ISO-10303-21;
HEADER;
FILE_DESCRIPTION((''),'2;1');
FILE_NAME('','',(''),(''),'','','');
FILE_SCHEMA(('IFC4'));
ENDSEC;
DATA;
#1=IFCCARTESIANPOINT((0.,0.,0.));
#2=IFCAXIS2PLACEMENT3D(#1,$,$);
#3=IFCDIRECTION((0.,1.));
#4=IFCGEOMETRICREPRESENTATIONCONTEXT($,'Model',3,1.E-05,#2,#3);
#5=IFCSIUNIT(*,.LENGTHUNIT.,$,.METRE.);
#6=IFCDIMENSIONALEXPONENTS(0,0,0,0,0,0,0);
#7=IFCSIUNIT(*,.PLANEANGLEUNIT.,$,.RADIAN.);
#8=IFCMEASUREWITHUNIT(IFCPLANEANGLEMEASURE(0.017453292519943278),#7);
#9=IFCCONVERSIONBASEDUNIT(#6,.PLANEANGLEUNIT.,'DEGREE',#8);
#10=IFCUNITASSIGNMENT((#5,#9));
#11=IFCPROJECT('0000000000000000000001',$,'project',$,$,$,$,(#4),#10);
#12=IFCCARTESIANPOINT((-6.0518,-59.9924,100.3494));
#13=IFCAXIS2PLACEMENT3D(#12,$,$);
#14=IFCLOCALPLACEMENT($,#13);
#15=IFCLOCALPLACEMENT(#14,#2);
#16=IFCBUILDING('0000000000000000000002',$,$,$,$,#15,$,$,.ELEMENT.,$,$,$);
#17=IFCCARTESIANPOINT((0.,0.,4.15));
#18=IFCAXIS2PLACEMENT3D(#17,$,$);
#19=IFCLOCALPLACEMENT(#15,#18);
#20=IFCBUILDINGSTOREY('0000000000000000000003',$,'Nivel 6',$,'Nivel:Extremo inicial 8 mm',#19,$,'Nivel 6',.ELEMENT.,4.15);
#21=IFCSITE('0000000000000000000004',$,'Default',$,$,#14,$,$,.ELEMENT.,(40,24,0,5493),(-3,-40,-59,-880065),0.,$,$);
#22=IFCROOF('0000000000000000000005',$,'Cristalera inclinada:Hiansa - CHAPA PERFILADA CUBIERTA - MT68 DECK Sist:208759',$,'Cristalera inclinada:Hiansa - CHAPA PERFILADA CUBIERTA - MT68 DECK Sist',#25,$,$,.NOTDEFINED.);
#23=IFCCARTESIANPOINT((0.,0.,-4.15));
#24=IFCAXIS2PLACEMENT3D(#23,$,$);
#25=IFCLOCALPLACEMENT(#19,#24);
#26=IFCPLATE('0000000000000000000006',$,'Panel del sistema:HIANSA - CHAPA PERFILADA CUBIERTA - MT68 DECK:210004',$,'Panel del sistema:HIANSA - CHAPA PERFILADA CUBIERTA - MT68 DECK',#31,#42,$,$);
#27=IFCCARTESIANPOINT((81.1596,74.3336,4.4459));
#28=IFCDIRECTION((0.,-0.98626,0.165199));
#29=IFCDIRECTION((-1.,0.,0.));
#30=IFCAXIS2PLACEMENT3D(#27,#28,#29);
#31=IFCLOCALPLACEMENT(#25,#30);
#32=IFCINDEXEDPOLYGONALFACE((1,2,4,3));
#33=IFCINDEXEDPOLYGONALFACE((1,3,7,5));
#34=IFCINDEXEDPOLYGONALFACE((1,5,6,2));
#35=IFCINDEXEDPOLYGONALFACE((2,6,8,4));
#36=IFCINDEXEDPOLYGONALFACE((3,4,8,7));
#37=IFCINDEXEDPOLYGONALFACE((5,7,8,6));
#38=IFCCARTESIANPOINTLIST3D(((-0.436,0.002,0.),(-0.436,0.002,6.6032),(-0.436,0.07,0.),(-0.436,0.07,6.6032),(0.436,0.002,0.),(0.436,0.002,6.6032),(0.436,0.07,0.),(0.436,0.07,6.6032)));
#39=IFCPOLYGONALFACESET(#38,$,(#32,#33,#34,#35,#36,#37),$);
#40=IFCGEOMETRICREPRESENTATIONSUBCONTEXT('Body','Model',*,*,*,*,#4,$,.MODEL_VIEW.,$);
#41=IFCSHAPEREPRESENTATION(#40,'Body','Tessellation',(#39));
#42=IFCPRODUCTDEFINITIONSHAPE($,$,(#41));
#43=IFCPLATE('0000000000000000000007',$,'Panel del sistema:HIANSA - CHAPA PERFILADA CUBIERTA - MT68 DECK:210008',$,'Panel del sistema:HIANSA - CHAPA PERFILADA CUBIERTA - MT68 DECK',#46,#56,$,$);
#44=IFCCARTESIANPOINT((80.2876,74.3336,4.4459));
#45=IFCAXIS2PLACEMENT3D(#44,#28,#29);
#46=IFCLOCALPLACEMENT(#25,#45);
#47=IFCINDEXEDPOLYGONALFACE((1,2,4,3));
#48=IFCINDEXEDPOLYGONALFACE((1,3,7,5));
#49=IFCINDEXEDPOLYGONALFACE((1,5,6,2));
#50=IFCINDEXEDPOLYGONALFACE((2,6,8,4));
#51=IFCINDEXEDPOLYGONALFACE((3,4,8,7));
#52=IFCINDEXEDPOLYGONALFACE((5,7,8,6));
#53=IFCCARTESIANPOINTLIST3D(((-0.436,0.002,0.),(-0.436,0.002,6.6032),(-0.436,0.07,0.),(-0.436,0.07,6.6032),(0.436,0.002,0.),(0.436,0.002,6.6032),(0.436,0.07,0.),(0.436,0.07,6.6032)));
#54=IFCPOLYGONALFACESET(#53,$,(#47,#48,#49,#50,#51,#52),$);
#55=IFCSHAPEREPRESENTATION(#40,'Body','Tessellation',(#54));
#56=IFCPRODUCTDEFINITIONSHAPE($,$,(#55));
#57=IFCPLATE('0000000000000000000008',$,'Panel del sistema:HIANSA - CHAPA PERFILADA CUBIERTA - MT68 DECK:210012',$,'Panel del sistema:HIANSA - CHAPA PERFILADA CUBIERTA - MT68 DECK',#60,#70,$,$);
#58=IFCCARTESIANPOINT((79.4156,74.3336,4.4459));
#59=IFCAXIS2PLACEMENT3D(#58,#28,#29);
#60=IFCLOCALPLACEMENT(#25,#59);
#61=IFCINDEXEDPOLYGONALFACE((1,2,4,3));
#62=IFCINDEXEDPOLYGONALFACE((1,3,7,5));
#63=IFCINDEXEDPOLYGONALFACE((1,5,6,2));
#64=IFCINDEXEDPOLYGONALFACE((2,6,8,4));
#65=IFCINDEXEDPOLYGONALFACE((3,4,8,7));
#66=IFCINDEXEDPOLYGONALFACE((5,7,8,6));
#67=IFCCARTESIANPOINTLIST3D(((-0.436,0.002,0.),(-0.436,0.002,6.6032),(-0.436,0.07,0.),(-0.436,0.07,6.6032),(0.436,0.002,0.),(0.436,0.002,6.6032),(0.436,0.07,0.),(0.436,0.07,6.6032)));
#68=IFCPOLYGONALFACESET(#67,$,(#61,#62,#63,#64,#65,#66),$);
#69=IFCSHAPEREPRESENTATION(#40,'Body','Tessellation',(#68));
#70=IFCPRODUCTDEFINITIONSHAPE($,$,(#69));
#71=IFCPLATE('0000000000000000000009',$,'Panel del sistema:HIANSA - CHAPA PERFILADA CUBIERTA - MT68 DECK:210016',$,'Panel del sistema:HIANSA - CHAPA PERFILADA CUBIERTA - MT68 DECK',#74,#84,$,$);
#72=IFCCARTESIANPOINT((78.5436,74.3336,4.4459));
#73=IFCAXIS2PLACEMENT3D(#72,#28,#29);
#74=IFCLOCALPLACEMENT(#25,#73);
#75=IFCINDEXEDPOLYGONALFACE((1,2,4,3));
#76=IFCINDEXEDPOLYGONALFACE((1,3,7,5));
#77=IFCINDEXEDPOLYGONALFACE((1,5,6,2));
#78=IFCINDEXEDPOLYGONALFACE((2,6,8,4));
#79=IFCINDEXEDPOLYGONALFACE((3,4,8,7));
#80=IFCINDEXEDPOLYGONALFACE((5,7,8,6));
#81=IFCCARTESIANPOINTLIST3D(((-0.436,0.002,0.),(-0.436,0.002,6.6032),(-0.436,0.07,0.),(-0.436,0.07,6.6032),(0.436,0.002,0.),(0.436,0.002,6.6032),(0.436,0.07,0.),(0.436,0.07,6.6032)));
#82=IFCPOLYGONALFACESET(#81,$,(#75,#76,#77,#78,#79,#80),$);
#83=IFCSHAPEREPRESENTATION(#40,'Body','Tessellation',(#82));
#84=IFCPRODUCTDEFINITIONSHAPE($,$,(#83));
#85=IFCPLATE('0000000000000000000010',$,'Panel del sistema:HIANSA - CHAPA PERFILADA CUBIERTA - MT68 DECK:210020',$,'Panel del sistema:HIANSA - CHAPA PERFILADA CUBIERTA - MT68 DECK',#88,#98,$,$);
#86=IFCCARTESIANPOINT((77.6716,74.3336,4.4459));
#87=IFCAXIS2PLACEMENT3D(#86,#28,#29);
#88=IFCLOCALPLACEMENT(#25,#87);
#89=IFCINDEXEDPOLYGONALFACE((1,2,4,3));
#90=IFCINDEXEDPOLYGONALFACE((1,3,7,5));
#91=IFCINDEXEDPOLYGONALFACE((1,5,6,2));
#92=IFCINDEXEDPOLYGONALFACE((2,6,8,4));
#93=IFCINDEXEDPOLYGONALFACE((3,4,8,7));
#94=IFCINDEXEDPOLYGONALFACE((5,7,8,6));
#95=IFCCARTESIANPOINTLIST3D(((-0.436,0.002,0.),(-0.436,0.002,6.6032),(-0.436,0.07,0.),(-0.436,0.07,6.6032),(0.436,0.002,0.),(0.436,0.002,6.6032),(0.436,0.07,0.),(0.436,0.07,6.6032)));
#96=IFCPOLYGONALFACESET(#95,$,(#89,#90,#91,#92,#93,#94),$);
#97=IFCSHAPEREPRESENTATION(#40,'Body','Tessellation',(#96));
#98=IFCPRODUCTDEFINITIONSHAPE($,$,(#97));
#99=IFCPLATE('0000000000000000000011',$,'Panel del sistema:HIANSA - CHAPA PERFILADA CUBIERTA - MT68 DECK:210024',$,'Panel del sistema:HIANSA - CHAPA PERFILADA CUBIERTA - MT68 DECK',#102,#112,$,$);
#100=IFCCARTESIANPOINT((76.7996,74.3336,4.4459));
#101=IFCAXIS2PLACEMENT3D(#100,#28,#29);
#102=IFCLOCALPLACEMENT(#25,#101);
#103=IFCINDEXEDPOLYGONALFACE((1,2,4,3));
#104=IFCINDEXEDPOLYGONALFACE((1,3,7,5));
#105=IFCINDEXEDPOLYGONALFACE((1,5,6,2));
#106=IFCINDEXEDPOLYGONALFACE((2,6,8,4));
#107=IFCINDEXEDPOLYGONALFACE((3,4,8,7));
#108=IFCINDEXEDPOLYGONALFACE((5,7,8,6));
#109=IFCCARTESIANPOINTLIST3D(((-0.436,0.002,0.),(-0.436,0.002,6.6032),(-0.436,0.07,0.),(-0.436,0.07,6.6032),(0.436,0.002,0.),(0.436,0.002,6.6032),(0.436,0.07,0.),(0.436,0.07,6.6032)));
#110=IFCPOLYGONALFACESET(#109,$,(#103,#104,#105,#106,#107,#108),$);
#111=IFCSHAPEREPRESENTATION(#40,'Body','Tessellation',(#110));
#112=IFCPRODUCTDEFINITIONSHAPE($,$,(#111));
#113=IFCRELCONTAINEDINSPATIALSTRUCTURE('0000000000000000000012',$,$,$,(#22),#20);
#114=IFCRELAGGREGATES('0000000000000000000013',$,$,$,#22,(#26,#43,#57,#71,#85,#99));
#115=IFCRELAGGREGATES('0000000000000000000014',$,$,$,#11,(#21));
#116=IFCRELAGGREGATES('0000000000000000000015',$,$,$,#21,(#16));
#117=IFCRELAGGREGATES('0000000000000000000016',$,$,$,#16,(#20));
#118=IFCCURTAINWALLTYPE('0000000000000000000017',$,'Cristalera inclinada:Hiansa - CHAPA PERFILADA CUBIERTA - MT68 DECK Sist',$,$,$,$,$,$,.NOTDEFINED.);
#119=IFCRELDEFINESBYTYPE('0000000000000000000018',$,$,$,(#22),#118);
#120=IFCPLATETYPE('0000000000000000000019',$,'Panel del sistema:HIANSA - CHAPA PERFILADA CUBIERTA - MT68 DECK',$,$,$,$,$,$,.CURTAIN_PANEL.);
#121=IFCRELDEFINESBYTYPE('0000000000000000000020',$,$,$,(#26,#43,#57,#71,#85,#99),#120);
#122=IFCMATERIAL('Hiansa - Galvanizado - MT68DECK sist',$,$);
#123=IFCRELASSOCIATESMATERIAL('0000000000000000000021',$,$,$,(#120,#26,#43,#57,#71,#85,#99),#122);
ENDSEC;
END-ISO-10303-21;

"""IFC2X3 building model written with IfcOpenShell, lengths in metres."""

from ifc_helpers import new_model, entity, si_unit, converted_unit, direction, frame, origin, origin_2d_with_axis, place, context, subcontext, project, spatial, rectangle, extrude, source, transform, mapped, material, type_object, type_shapes, element, aggregate, save


model = new_model("IFC2X3")

# Units and contexts
model_context = context("Model", 3, precision=1e-05, world=origin(), true_north=direction((0.0, 1.0)))
body_context = subcontext(model_context, "Body", "Model", "MODEL_VIEW")
ifc_project = project(units=[si_unit("LENGTHUNIT", "METRE"), converted_unit("PLANEANGLEUNIT", "DEGREE", entity("IfcPlaneAngleMeasure", 0.017453292519943278), si_unit("PLANEANGLEUNIT", "RADIAN"), dimensions=[0, 0, 0, 0, 0, 0, 0])], contexts=[model_context])

# Site, building, storey
site_placement = place(None, frame((-6.0518, -59.9924, 100.3494)))
site = spatial("IfcSite", under=ifc_project, at=site_placement, Name="Default", CompositionType="ELEMENT", RefLatitude=(40, 24, 0, 5493), RefLongitude=(-3, -40, -59, -880065), RefElevation=0.0)
building_placement = place(site_placement, origin())
building = spatial("IfcBuilding", under=site, at=building_placement, CompositionType="ELEMENT")
storey_placement = place(building_placement, frame((0.0, 0.0, 4.15)))
storey = spatial("IfcBuildingStorey", under=building, at=storey_placement, Name="Nivel 6", ObjectType="Nivel:Extremo inicial 8 mm", LongName="Nivel 6", CompositionType="ELEMENT", Elevation=4.15)

# Roof, plates
curtain_wall_type = type_object("IfcCurtainWallType", Name="Cristalera inclinada:Hiansa - CHAPA PERFILADA CUBIERTA - MT68 DECK Sist", PredefinedType="NOTDEFINED")
roof_placement = place(storey_placement, frame((0.0, 0.0, -4.15)))
roof = element("IfcRoof", 1, at=roof_placement, inside=storey, type_object=curtain_wall_type, Name="Cristalera inclinada:Hiansa - CHAPA PERFILADA CUBIERTA - MT68 DECK Sist:208759", ObjectType="Cristalera inclinada:Hiansa - CHAPA PERFILADA CUBIERTA - MT68 DECK Sist", ShapeType="NOTDEFINED")
ifc_material_1 = material(Name="Hiansa - Galvanizado - MT68DECK sist")
plate_type_1 = type_object("IfcPlateType", Name="Panel del sistema:HIANSA - CHAPA PERFILADA CUBIERTA - MT68 DECK", PredefinedType="CURTAIN_PANEL", material=ifc_material_1)
shared_shape_1 = source(origin(), body_context, "Body", "SweptSolid", [
    extrude(rectangle(XDim=0.068, YDim=0.872, at=origin_2d_with_axis()), frame((0.0, 0.036, 0.0), z_axis=(0.0, 0.0, 1.0), x_axis=(0.0, 1.0, 0.0)), (0.0, 0.0, 1.0), 6.6032),
])
type_shapes(plate_type_1, [shared_shape_1])
plate_1_placement = place(roof_placement, frame((81.1596, 74.3336, 4.4459), z_axis=(0.0, -0.98626, 0.165199), x_axis=(-1.0, 0.0, 0.0)))
plate_1 = element("IfcPlate", 2, at=plate_1_placement, type_object=plate_type_1, material=ifc_material_1, Name="Panel del sistema:HIANSA - CHAPA PERFILADA CUBIERTA - MT68 DECK:210004", ObjectType="Panel del sistema:HIANSA - CHAPA PERFILADA CUBIERTA - MT68 DECK", context=body_context, shape_type="MappedRepresentation", body=[
    mapped(shared_shape_1, transform((0.0, 0.0, 0.0), scale=1.0)),
])
plate_2_placement = place(roof_placement, frame((80.2876, 74.3336, 4.4459), z_axis=(0.0, -0.98626, 0.165199), x_axis=(-1.0, 0.0, 0.0)))
plate_2 = element("IfcPlate", 3, at=plate_2_placement, type_object=plate_type_1, material=ifc_material_1, Name="Panel del sistema:HIANSA - CHAPA PERFILADA CUBIERTA - MT68 DECK:210008", ObjectType="Panel del sistema:HIANSA - CHAPA PERFILADA CUBIERTA - MT68 DECK", context=body_context, shape_type="MappedRepresentation", body=[
    mapped(shared_shape_1, transform((0.0, 0.0, 0.0), scale=1.0)),
])
plate_3_placement = place(roof_placement, frame((79.4156, 74.3336, 4.4459), z_axis=(0.0, -0.98626, 0.165199), x_axis=(-1.0, 0.0, 0.0)))
plate_3 = element("IfcPlate", 4, at=plate_3_placement, type_object=plate_type_1, material=ifc_material_1, Name="Panel del sistema:HIANSA - CHAPA PERFILADA CUBIERTA - MT68 DECK:210012", ObjectType="Panel del sistema:HIANSA - CHAPA PERFILADA CUBIERTA - MT68 DECK", context=body_context, shape_type="MappedRepresentation", body=[
    mapped(shared_shape_1, transform((0.0, 0.0, 0.0), scale=1.0)),
])
plate_4_placement = place(roof_placement, frame((78.5436, 74.3336, 4.4459), z_axis=(0.0, -0.98626, 0.165199), x_axis=(-1.0, 0.0, 0.0)))
plate_4 = element("IfcPlate", 5, at=plate_4_placement, type_object=plate_type_1, material=ifc_material_1, Name="Panel del sistema:HIANSA - CHAPA PERFILADA CUBIERTA - MT68 DECK:210016", ObjectType="Panel del sistema:HIANSA - CHAPA PERFILADA CUBIERTA - MT68 DECK", context=body_context, shape_type="MappedRepresentation", body=[
    mapped(shared_shape_1, transform((0.0, 0.0, 0.0), scale=1.0)),
])
plate_5_placement = place(roof_placement, frame((77.6716, 74.3336, 4.4459), z_axis=(0.0, -0.98626, 0.165199), x_axis=(-1.0, 0.0, 0.0)))
plate_5 = element("IfcPlate", 6, at=plate_5_placement, type_object=plate_type_1, material=ifc_material_1, Name="Panel del sistema:HIANSA - CHAPA PERFILADA CUBIERTA - MT68 DECK:210020", ObjectType="Panel del sistema:HIANSA - CHAPA PERFILADA CUBIERTA - MT68 DECK", context=body_context, shape_type="MappedRepresentation", body=[
    mapped(shared_shape_1, transform((0.0, 0.0, 0.0), scale=1.0)),
])
plate_6_placement = place(roof_placement, frame((76.7996, 74.3336, 4.4459), z_axis=(0.0, -0.98626, 0.165199), x_axis=(-1.0, 0.0, 0.0)))
plate_6 = element("IfcPlate", 7, at=plate_6_placement, type_object=plate_type_1, material=ifc_material_1, Name="Panel del sistema:HIANSA - CHAPA PERFILADA CUBIERTA - MT68 DECK:210024", ObjectType="Panel del sistema:HIANSA - CHAPA PERFILADA CUBIERTA - MT68 DECK", context=body_context, shape_type="MappedRepresentation", body=[
    mapped(shared_shape_1, transform((0.0, 0.0, 0.0), scale=1.0)),
])
aggregate(roof, [plate_1, plate_2, plate_3, plate_4, plate_5, plate_6])

save(model, "model.ifc")
